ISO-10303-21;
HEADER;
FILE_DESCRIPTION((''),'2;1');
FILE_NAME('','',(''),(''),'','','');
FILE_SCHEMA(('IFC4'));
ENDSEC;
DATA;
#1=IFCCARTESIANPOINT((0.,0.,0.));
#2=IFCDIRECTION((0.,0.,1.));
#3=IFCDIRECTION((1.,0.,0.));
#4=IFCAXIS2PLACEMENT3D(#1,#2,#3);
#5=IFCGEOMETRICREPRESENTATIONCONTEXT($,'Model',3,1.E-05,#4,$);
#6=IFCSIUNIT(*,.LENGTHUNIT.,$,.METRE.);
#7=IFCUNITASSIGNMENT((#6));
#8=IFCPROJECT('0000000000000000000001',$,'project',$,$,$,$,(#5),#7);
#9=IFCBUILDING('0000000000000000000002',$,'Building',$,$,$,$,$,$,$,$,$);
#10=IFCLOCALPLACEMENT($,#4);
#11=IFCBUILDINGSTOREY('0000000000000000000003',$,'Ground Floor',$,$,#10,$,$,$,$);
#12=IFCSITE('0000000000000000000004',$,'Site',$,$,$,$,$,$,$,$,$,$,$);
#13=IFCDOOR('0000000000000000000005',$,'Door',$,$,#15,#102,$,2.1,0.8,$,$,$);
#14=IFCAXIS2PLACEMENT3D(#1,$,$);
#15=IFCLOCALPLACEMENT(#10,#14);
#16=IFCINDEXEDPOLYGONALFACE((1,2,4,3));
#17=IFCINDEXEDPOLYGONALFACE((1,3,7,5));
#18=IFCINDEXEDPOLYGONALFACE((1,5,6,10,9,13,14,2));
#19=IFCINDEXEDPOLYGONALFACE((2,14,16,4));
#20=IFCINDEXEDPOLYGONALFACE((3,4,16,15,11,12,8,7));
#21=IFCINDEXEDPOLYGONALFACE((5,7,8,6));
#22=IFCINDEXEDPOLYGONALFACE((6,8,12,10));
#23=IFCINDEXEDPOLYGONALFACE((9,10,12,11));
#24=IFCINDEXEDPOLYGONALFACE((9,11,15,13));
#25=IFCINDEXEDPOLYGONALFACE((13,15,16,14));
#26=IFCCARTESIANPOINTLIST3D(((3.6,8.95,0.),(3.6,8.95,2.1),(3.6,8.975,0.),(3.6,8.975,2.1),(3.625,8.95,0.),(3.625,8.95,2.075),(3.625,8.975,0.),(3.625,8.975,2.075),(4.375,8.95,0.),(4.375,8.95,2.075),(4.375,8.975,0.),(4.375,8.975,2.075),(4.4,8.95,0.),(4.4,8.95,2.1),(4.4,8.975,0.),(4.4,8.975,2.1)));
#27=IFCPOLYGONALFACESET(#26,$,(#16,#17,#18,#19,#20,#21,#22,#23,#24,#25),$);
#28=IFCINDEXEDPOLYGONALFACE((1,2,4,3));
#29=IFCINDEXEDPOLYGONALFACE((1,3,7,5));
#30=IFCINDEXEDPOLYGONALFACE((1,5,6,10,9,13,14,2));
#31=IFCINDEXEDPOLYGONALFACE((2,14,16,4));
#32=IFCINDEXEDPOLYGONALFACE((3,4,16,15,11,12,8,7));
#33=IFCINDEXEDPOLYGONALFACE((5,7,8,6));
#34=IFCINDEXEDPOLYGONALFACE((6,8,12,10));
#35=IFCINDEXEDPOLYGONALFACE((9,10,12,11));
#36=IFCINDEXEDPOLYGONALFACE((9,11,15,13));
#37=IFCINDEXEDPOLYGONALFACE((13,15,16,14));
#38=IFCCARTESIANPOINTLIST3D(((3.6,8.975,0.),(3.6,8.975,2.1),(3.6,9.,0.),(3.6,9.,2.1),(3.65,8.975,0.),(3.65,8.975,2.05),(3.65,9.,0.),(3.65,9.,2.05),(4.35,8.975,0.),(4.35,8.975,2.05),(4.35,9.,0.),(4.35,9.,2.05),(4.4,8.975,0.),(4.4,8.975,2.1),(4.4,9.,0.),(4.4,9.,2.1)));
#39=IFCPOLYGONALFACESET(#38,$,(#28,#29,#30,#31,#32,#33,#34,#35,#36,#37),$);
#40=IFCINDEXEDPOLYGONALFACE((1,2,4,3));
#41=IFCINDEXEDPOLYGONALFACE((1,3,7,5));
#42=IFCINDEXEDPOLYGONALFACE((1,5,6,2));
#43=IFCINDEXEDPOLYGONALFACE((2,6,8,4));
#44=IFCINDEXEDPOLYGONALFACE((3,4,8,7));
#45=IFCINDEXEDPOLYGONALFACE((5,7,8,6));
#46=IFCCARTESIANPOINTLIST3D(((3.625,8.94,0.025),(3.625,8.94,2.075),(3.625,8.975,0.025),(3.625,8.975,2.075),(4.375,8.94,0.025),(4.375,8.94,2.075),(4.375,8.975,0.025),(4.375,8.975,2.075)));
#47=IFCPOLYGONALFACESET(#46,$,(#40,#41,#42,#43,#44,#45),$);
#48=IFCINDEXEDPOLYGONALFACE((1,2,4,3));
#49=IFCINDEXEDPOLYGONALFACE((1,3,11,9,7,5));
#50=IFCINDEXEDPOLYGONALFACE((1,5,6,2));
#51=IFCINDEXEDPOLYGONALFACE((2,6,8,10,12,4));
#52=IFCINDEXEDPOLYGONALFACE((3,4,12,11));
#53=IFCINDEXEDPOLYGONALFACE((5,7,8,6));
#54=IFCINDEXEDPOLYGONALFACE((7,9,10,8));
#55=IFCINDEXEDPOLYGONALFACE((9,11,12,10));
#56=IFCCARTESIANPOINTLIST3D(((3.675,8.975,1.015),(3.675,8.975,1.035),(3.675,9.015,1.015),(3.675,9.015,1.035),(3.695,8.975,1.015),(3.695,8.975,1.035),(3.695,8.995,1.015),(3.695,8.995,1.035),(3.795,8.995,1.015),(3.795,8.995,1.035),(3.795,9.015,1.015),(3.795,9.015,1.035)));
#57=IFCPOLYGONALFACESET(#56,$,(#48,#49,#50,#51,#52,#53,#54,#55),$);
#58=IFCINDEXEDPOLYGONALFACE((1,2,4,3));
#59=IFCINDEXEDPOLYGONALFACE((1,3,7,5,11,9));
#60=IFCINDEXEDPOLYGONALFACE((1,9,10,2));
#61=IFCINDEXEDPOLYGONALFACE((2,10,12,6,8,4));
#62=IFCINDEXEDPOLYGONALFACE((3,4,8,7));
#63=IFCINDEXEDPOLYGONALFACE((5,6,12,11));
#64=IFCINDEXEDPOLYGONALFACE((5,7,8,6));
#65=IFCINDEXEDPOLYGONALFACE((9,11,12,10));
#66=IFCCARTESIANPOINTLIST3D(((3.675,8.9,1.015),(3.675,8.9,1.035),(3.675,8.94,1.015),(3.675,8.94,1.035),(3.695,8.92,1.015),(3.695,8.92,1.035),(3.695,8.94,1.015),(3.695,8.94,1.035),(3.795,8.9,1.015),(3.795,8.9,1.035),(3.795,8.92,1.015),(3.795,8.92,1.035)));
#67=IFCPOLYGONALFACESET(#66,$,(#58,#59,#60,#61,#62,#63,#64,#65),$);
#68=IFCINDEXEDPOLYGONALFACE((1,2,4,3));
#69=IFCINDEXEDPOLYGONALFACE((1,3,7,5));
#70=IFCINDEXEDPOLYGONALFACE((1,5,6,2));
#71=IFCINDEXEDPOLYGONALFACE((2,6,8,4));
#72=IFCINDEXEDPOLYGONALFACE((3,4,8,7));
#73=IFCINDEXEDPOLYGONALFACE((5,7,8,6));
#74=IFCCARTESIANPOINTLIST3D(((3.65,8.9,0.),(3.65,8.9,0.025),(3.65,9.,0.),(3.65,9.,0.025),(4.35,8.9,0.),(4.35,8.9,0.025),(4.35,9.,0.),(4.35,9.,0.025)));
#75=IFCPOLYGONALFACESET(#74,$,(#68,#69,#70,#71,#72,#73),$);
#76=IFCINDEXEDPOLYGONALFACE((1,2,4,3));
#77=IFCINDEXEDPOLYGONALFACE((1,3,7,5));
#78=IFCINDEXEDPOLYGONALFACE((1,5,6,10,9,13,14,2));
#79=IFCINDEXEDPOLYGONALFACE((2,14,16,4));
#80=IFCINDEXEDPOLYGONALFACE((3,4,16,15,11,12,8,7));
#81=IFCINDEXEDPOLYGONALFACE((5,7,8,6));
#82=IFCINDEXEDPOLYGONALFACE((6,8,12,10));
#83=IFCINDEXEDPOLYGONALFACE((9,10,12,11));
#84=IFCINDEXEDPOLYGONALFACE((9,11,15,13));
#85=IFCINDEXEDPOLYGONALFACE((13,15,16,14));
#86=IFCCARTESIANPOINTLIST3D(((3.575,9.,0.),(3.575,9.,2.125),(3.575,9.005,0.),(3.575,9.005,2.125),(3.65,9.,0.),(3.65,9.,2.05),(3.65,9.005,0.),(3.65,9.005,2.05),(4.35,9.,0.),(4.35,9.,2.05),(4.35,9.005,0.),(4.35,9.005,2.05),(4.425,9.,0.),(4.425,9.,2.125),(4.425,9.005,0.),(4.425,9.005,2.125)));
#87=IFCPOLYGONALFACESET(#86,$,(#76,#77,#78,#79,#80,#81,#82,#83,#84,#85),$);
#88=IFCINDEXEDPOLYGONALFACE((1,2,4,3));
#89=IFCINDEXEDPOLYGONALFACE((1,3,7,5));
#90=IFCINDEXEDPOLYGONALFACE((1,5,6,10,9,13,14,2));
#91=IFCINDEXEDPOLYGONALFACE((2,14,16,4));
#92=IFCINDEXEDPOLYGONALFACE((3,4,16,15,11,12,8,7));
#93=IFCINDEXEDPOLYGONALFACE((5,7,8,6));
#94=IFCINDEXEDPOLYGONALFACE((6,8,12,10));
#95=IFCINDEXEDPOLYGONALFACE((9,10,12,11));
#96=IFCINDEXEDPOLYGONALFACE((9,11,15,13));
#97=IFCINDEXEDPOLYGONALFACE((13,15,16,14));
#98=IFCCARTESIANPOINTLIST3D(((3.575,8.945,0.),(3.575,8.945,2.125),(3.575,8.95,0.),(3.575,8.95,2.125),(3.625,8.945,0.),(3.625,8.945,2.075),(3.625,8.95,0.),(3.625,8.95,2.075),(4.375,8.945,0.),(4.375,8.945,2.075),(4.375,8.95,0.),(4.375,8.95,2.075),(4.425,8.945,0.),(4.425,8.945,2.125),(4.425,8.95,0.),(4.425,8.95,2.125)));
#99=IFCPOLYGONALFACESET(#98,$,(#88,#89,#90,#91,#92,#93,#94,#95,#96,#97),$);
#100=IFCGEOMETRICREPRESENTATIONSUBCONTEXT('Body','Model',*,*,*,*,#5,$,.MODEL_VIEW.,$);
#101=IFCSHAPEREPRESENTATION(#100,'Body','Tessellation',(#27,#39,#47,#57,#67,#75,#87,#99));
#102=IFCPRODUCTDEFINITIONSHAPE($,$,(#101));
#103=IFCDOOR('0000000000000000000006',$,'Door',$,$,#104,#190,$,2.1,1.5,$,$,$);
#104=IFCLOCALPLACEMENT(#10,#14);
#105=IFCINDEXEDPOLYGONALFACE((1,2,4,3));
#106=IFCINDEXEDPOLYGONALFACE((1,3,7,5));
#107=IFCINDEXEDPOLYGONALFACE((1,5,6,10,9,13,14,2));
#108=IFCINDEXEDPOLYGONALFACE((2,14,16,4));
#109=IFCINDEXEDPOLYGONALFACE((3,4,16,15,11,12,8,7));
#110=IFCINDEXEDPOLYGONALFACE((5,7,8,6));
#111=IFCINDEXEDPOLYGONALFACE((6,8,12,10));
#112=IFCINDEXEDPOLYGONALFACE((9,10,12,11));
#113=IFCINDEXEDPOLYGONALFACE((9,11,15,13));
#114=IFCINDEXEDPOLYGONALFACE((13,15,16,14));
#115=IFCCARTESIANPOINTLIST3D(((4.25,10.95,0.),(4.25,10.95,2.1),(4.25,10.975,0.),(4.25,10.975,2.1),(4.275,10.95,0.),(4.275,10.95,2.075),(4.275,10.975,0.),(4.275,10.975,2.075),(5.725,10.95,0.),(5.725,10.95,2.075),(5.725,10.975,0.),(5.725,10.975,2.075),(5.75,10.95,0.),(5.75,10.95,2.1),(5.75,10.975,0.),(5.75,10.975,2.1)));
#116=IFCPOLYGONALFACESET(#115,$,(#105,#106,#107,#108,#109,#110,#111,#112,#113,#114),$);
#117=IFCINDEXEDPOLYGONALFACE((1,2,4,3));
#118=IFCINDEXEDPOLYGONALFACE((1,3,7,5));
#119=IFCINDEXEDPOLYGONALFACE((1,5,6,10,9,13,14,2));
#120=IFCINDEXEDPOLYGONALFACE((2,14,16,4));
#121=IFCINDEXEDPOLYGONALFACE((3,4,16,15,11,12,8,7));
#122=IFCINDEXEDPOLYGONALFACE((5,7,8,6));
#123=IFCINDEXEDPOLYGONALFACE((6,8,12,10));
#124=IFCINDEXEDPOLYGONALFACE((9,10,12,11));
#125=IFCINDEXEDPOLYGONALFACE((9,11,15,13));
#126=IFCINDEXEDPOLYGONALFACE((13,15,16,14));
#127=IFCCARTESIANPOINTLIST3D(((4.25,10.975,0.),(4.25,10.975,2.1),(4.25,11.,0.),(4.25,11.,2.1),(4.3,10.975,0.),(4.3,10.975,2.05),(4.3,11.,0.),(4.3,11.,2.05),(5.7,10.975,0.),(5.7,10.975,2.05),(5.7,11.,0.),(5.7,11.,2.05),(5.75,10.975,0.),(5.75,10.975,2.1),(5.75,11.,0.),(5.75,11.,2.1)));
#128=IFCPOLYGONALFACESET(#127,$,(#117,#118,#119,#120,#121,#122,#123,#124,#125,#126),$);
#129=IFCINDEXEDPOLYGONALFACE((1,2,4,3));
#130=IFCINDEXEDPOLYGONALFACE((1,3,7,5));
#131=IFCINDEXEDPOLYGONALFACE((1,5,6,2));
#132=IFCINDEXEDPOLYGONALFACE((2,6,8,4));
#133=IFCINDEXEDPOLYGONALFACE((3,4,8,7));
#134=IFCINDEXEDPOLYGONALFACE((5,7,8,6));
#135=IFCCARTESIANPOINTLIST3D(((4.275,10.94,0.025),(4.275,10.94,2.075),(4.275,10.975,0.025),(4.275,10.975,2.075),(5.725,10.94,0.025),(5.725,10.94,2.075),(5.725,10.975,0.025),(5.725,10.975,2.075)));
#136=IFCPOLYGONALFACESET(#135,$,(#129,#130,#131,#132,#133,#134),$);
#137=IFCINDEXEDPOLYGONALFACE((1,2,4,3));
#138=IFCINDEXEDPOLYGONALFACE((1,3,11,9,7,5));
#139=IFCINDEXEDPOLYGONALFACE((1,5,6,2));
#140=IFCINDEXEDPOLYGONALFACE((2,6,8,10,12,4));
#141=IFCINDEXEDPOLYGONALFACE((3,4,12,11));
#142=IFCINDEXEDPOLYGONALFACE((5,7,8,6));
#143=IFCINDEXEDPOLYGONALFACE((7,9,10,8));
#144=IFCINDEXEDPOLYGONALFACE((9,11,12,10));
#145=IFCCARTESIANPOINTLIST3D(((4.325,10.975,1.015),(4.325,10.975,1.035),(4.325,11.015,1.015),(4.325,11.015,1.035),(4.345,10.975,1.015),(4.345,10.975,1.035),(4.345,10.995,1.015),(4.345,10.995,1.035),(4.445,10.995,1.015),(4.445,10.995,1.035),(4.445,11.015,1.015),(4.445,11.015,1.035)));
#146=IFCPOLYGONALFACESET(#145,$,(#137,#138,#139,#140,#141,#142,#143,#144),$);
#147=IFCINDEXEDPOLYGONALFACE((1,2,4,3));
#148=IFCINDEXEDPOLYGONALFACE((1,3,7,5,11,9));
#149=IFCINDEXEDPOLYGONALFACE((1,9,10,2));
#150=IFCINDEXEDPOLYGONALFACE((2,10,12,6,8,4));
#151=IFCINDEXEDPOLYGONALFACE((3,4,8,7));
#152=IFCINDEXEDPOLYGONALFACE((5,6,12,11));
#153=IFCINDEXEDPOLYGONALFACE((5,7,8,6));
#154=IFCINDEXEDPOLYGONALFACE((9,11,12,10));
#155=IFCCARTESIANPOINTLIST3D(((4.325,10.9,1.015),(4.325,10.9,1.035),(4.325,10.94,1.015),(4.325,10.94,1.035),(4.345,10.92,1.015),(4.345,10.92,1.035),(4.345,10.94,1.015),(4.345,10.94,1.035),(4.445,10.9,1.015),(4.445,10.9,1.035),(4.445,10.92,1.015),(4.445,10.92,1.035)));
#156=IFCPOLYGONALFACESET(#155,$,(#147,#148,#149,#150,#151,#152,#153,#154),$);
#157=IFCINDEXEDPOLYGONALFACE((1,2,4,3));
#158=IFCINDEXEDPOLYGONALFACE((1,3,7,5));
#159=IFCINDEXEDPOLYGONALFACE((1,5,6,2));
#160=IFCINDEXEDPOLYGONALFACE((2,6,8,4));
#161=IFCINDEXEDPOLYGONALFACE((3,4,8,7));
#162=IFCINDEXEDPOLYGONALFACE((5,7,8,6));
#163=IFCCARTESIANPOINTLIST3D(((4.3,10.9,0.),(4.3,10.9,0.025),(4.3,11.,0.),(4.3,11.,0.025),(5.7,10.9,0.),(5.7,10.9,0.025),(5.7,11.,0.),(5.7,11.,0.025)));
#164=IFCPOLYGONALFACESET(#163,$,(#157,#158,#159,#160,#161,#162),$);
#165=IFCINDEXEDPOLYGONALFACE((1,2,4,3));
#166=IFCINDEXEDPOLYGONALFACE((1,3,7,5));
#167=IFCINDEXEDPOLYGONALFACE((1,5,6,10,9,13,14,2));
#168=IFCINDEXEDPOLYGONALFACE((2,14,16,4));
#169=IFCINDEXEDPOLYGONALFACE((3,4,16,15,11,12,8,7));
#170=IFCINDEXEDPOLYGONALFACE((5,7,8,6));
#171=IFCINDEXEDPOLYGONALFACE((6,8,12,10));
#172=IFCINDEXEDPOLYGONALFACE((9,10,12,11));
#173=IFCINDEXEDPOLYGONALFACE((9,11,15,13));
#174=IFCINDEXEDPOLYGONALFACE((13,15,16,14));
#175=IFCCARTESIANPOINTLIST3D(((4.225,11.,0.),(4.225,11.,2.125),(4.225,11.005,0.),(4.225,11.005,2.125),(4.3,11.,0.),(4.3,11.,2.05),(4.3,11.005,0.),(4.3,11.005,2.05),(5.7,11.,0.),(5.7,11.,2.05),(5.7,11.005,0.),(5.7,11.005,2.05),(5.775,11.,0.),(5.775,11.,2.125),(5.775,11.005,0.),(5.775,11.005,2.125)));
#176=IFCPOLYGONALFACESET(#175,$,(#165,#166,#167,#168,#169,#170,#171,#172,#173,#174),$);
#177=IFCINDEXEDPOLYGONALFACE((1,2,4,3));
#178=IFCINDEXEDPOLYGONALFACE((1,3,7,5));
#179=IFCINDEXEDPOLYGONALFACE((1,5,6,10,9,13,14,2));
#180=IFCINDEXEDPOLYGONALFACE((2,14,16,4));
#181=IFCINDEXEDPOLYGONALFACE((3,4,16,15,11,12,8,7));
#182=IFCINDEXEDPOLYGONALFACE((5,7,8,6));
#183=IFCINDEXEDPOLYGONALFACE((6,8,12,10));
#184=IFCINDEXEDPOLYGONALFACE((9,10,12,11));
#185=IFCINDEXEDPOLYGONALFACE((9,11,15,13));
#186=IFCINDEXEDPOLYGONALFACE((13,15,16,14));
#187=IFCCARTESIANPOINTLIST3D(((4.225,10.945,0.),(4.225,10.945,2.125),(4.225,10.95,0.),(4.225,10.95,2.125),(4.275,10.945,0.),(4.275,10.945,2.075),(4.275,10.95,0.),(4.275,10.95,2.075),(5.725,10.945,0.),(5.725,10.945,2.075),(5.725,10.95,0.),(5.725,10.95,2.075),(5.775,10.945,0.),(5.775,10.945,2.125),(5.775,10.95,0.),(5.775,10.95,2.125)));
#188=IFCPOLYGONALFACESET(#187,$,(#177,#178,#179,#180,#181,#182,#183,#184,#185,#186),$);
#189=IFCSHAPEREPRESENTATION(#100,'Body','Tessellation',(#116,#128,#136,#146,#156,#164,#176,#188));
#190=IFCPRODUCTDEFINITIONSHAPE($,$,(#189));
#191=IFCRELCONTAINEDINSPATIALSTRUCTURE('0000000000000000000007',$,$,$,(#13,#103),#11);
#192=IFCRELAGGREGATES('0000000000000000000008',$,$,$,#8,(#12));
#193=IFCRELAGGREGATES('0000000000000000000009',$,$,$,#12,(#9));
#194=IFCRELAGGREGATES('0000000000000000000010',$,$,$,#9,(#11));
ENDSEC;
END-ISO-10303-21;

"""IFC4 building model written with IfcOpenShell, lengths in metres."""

from ifc_helpers import new_model, si_unit, frame, origin_with_axes, place, context, subcontext, project, spatial, line, indexed_curve, outline, extrude, element, save


model = new_model("IFC4")

# Units and contexts
model_context = context("Model", 3, precision=1e-05, world=origin_with_axes())
body_context = subcontext(model_context, "Body", "Model", "MODEL_VIEW")
ifc_project = project(units=[si_unit("LENGTHUNIT", "METRE")], contexts=[model_context])

# Site, building, storey
site = spatial("IfcSite", under=ifc_project, Name="Site")
building = spatial("IfcBuilding", under=site, Name="Building")
storey_placement = place(None, origin_with_axes())
storey = spatial("IfcBuildingStorey", under=building, at=storey_placement, Name="Ground Floor")

# Doors
door_1_placement = place(storey_placement, frame((4.4, 9.0, 0.0), z_axis=(0.0, 0.0, 1.0), x_axis=(-1.0, 0.0, 0.0)))
element("IfcDoor", 1, at=door_1_placement, inside=storey, Name="Door", OverallHeight=2.1, OverallWidth=0.8, context=body_context, shape_type="SweptSolid", body=[
    extrude(outline(indexed_curve([(0.0, 0.0), (0.0, 2.1), (0.8, 2.1), (0.8, 0.0), (0.775, 0.0), (0.775, 2.075), (0.025, 2.075), (0.025, 0.0)], segments=[line(1, 2, 3, 4, 5, 6, 7, 8, 1)])), frame((0.0, 0.025, 0.0), z_axis=(0.0, -1.0, 0.0), x_axis=(1.0, 0.0, 0.0)), (0.0, 0.0, -1.0), 0.025),
    extrude(outline(indexed_curve([(0.0, 0.0), (0.0, 2.1), (0.8, 2.1), (0.8, 0.0), (0.75, 0.0), (0.75, 2.05), (0.05, 2.05), (0.05, 0.0)], segments=[line(1, 2, 3, 4, 5, 6, 7, 8, 1)])), frame((0.0, 0.0, 0.0), z_axis=(0.0, -1.0, 0.0), x_axis=(1.0, 0.0, 0.0)), (0.0, 0.0, -1.0), 0.025),
    extrude(outline(indexed_curve([(0.0, 0.0), (0.75, 0.0), (0.75, 0.035), (0.0, 0.035)], segments=[line(1, 2, 3, 4, 1)])), frame((0.025, 0.025, 0.025), z_axis=(0.0, 0.0, 1.0), x_axis=(1.0, 0.0, 0.0)), (0.0, 0.0, 1.0), 2.05),
    extrude(outline(indexed_curve([(0.0, 0.0), (0.0, -0.04), (-0.12, -0.04), (-0.12, -0.02), (-0.02, -0.02), (-0.02, 0.0)], segments=[line(1, 2, 3, 4, 5, 6, 1)])), frame((0.725, 0.025, 1.015), z_axis=(0.0, 0.0, 1.0), x_axis=(1.0, 0.0, 0.0)), (0.0, 0.0, 1.0), 0.02),
    extrude(outline(indexed_curve([(0.0, 0.0), (0.0, 0.04), (-0.12, 0.04), (-0.12, 0.02), (-0.02, 0.02), (-0.02, 0.0)], segments=[line(1, 2, 3, 4, 5, 6, 1)])), frame((0.725, 0.06, 1.015), z_axis=(0.0, 0.0, 1.0), x_axis=(1.0, 0.0, 0.0)), (0.0, 0.0, 1.0), 0.02),
    extrude(outline(indexed_curve([(0.0, 0.0), (0.7, 0.0), (0.7, 0.1), (0.0, 0.1)], segments=[line(1, 2, 3, 4, 1)])), frame((0.05, 0.0, 0.0), z_axis=(0.0, 0.0, 1.0), x_axis=(1.0, 0.0, 0.0)), (0.0, 0.0, 1.0), 0.025),
    extrude(outline(indexed_curve([(0.0, 0.0), (0.0, 2.125), (0.85, 2.125), (0.85, 0.0), (0.775, 0.0), (0.775, 2.05), (0.075, 2.05), (0.075, 0.0)], segments=[line(1, 2, 3, 4, 5, 6, 7, 8, 1)])), frame((-0.025, -0.005, 0.0), z_axis=(0.0, -1.0, 0.0), x_axis=(1.0, 0.0, 0.0)), (0.0, 0.0, -1.0), 0.005),
    extrude(outline(indexed_curve([(0.0, 0.0), (0.0, 2.125), (0.85, 2.125), (0.85, 0.0), (0.8, 0.0), (0.8, 2.075), (0.05, 2.075), (0.05, 0.0)], segments=[line(1, 2, 3, 4, 5, 6, 7, 8, 1)])), frame((-0.025, 0.05, 0.0), z_axis=(0.0, -1.0, 0.0), x_axis=(1.0, 0.0, 0.0)), (0.0, 0.0, -1.0), 0.005),
])
door_2_placement = place(storey_placement, frame((5.75, 11.0, 0.0), z_axis=(0.0, 0.0, 1.0), x_axis=(-1.0, 0.0, 0.0)))
element("IfcDoor", 2, at=door_2_placement, inside=storey, Name="Door", OverallHeight=2.1, OverallWidth=1.5, context=body_context, shape_type="SweptSolid", body=[
    extrude(outline(indexed_curve([(0.0, 0.0), (0.0, 2.1), (1.5, 2.1), (1.5, 0.0), (1.475, 0.0), (1.475, 2.075), (0.025, 2.075), (0.025, 0.0)], segments=[line(1, 2, 3, 4, 5, 6, 7, 8, 1)])), frame((0.0, 0.025, 0.0), z_axis=(0.0, -1.0, 0.0), x_axis=(1.0, 0.0, 0.0)), (0.0, 0.0, -1.0), 0.025),
    extrude(outline(indexed_curve([(0.0, 0.0), (0.0, 2.1), (1.5, 2.1), (1.5, 0.0), (1.45, 0.0), (1.45, 2.05), (0.05, 2.05), (0.05, 0.0)], segments=[line(1, 2, 3, 4, 5, 6, 7, 8, 1)])), frame((0.0, 0.0, 0.0), z_axis=(0.0, -1.0, 0.0), x_axis=(1.0, 0.0, 0.0)), (0.0, 0.0, -1.0), 0.025),
    extrude(outline(indexed_curve([(0.0, 0.0), (1.45, 0.0), (1.45, 0.035), (0.0, 0.035)], segments=[line(1, 2, 3, 4, 1)])), frame((0.025, 0.025, 0.025), z_axis=(0.0, 0.0, 1.0), x_axis=(1.0, 0.0, 0.0)), (0.0, 0.0, 1.0), 2.05),
    extrude(outline(indexed_curve([(0.0, 0.0), (0.0, -0.04), (-0.12, -0.04), (-0.12, -0.02), (-0.02, -0.02), (-0.02, 0.0)], segments=[line(1, 2, 3, 4, 5, 6, 1)])), frame((1.425, 0.025, 1.015), z_axis=(0.0, 0.0, 1.0), x_axis=(1.0, 0.0, 0.0)), (0.0, 0.0, 1.0), 0.02),
    extrude(outline(indexed_curve([(0.0, 0.0), (0.0, 0.04), (-0.12, 0.04), (-0.12, 0.02), (-0.02, 0.02), (-0.02, 0.0)], segments=[line(1, 2, 3, 4, 5, 6, 1)])), frame((1.425, 0.06, 1.015), z_axis=(0.0, 0.0, 1.0), x_axis=(1.0, 0.0, 0.0)), (0.0, 0.0, 1.0), 0.02),
    extrude(outline(indexed_curve([(0.0, 0.0), (1.4, 0.0), (1.4, 0.1), (0.0, 0.1)], segments=[line(1, 2, 3, 4, 1)])), frame((0.05, 0.0, 0.0), z_axis=(0.0, 0.0, 1.0), x_axis=(1.0, 0.0, 0.0)), (0.0, 0.0, 1.0), 0.025),
    extrude(outline(indexed_curve([(0.0, 0.0), (0.0, 2.125), (1.55, 2.125), (1.55, 0.0), (1.475, 0.0), (1.475, 2.05), (0.075, 2.05), (0.075, 0.0)], segments=[line(1, 2, 3, 4, 5, 6, 7, 8, 1)])), frame((-0.025, -0.005, 0.0), z_axis=(0.0, -1.0, 0.0), x_axis=(1.0, 0.0, 0.0)), (0.0, 0.0, -1.0), 0.005),
    extrude(outline(indexed_curve([(0.0, 0.0), (0.0, 2.125), (1.55, 2.125), (1.55, 0.0), (1.5, 0.0), (1.5, 2.075), (0.05, 2.075), (0.05, 0.0)], segments=[line(1, 2, 3, 4, 5, 6, 7, 8, 1)])), frame((-0.025, 0.05, 0.0), z_axis=(0.0, -1.0, 0.0), x_axis=(1.0, 0.0, 0.0)), (0.0, 0.0, -1.0), 0.005),
])

save(model, "model.ifc")
